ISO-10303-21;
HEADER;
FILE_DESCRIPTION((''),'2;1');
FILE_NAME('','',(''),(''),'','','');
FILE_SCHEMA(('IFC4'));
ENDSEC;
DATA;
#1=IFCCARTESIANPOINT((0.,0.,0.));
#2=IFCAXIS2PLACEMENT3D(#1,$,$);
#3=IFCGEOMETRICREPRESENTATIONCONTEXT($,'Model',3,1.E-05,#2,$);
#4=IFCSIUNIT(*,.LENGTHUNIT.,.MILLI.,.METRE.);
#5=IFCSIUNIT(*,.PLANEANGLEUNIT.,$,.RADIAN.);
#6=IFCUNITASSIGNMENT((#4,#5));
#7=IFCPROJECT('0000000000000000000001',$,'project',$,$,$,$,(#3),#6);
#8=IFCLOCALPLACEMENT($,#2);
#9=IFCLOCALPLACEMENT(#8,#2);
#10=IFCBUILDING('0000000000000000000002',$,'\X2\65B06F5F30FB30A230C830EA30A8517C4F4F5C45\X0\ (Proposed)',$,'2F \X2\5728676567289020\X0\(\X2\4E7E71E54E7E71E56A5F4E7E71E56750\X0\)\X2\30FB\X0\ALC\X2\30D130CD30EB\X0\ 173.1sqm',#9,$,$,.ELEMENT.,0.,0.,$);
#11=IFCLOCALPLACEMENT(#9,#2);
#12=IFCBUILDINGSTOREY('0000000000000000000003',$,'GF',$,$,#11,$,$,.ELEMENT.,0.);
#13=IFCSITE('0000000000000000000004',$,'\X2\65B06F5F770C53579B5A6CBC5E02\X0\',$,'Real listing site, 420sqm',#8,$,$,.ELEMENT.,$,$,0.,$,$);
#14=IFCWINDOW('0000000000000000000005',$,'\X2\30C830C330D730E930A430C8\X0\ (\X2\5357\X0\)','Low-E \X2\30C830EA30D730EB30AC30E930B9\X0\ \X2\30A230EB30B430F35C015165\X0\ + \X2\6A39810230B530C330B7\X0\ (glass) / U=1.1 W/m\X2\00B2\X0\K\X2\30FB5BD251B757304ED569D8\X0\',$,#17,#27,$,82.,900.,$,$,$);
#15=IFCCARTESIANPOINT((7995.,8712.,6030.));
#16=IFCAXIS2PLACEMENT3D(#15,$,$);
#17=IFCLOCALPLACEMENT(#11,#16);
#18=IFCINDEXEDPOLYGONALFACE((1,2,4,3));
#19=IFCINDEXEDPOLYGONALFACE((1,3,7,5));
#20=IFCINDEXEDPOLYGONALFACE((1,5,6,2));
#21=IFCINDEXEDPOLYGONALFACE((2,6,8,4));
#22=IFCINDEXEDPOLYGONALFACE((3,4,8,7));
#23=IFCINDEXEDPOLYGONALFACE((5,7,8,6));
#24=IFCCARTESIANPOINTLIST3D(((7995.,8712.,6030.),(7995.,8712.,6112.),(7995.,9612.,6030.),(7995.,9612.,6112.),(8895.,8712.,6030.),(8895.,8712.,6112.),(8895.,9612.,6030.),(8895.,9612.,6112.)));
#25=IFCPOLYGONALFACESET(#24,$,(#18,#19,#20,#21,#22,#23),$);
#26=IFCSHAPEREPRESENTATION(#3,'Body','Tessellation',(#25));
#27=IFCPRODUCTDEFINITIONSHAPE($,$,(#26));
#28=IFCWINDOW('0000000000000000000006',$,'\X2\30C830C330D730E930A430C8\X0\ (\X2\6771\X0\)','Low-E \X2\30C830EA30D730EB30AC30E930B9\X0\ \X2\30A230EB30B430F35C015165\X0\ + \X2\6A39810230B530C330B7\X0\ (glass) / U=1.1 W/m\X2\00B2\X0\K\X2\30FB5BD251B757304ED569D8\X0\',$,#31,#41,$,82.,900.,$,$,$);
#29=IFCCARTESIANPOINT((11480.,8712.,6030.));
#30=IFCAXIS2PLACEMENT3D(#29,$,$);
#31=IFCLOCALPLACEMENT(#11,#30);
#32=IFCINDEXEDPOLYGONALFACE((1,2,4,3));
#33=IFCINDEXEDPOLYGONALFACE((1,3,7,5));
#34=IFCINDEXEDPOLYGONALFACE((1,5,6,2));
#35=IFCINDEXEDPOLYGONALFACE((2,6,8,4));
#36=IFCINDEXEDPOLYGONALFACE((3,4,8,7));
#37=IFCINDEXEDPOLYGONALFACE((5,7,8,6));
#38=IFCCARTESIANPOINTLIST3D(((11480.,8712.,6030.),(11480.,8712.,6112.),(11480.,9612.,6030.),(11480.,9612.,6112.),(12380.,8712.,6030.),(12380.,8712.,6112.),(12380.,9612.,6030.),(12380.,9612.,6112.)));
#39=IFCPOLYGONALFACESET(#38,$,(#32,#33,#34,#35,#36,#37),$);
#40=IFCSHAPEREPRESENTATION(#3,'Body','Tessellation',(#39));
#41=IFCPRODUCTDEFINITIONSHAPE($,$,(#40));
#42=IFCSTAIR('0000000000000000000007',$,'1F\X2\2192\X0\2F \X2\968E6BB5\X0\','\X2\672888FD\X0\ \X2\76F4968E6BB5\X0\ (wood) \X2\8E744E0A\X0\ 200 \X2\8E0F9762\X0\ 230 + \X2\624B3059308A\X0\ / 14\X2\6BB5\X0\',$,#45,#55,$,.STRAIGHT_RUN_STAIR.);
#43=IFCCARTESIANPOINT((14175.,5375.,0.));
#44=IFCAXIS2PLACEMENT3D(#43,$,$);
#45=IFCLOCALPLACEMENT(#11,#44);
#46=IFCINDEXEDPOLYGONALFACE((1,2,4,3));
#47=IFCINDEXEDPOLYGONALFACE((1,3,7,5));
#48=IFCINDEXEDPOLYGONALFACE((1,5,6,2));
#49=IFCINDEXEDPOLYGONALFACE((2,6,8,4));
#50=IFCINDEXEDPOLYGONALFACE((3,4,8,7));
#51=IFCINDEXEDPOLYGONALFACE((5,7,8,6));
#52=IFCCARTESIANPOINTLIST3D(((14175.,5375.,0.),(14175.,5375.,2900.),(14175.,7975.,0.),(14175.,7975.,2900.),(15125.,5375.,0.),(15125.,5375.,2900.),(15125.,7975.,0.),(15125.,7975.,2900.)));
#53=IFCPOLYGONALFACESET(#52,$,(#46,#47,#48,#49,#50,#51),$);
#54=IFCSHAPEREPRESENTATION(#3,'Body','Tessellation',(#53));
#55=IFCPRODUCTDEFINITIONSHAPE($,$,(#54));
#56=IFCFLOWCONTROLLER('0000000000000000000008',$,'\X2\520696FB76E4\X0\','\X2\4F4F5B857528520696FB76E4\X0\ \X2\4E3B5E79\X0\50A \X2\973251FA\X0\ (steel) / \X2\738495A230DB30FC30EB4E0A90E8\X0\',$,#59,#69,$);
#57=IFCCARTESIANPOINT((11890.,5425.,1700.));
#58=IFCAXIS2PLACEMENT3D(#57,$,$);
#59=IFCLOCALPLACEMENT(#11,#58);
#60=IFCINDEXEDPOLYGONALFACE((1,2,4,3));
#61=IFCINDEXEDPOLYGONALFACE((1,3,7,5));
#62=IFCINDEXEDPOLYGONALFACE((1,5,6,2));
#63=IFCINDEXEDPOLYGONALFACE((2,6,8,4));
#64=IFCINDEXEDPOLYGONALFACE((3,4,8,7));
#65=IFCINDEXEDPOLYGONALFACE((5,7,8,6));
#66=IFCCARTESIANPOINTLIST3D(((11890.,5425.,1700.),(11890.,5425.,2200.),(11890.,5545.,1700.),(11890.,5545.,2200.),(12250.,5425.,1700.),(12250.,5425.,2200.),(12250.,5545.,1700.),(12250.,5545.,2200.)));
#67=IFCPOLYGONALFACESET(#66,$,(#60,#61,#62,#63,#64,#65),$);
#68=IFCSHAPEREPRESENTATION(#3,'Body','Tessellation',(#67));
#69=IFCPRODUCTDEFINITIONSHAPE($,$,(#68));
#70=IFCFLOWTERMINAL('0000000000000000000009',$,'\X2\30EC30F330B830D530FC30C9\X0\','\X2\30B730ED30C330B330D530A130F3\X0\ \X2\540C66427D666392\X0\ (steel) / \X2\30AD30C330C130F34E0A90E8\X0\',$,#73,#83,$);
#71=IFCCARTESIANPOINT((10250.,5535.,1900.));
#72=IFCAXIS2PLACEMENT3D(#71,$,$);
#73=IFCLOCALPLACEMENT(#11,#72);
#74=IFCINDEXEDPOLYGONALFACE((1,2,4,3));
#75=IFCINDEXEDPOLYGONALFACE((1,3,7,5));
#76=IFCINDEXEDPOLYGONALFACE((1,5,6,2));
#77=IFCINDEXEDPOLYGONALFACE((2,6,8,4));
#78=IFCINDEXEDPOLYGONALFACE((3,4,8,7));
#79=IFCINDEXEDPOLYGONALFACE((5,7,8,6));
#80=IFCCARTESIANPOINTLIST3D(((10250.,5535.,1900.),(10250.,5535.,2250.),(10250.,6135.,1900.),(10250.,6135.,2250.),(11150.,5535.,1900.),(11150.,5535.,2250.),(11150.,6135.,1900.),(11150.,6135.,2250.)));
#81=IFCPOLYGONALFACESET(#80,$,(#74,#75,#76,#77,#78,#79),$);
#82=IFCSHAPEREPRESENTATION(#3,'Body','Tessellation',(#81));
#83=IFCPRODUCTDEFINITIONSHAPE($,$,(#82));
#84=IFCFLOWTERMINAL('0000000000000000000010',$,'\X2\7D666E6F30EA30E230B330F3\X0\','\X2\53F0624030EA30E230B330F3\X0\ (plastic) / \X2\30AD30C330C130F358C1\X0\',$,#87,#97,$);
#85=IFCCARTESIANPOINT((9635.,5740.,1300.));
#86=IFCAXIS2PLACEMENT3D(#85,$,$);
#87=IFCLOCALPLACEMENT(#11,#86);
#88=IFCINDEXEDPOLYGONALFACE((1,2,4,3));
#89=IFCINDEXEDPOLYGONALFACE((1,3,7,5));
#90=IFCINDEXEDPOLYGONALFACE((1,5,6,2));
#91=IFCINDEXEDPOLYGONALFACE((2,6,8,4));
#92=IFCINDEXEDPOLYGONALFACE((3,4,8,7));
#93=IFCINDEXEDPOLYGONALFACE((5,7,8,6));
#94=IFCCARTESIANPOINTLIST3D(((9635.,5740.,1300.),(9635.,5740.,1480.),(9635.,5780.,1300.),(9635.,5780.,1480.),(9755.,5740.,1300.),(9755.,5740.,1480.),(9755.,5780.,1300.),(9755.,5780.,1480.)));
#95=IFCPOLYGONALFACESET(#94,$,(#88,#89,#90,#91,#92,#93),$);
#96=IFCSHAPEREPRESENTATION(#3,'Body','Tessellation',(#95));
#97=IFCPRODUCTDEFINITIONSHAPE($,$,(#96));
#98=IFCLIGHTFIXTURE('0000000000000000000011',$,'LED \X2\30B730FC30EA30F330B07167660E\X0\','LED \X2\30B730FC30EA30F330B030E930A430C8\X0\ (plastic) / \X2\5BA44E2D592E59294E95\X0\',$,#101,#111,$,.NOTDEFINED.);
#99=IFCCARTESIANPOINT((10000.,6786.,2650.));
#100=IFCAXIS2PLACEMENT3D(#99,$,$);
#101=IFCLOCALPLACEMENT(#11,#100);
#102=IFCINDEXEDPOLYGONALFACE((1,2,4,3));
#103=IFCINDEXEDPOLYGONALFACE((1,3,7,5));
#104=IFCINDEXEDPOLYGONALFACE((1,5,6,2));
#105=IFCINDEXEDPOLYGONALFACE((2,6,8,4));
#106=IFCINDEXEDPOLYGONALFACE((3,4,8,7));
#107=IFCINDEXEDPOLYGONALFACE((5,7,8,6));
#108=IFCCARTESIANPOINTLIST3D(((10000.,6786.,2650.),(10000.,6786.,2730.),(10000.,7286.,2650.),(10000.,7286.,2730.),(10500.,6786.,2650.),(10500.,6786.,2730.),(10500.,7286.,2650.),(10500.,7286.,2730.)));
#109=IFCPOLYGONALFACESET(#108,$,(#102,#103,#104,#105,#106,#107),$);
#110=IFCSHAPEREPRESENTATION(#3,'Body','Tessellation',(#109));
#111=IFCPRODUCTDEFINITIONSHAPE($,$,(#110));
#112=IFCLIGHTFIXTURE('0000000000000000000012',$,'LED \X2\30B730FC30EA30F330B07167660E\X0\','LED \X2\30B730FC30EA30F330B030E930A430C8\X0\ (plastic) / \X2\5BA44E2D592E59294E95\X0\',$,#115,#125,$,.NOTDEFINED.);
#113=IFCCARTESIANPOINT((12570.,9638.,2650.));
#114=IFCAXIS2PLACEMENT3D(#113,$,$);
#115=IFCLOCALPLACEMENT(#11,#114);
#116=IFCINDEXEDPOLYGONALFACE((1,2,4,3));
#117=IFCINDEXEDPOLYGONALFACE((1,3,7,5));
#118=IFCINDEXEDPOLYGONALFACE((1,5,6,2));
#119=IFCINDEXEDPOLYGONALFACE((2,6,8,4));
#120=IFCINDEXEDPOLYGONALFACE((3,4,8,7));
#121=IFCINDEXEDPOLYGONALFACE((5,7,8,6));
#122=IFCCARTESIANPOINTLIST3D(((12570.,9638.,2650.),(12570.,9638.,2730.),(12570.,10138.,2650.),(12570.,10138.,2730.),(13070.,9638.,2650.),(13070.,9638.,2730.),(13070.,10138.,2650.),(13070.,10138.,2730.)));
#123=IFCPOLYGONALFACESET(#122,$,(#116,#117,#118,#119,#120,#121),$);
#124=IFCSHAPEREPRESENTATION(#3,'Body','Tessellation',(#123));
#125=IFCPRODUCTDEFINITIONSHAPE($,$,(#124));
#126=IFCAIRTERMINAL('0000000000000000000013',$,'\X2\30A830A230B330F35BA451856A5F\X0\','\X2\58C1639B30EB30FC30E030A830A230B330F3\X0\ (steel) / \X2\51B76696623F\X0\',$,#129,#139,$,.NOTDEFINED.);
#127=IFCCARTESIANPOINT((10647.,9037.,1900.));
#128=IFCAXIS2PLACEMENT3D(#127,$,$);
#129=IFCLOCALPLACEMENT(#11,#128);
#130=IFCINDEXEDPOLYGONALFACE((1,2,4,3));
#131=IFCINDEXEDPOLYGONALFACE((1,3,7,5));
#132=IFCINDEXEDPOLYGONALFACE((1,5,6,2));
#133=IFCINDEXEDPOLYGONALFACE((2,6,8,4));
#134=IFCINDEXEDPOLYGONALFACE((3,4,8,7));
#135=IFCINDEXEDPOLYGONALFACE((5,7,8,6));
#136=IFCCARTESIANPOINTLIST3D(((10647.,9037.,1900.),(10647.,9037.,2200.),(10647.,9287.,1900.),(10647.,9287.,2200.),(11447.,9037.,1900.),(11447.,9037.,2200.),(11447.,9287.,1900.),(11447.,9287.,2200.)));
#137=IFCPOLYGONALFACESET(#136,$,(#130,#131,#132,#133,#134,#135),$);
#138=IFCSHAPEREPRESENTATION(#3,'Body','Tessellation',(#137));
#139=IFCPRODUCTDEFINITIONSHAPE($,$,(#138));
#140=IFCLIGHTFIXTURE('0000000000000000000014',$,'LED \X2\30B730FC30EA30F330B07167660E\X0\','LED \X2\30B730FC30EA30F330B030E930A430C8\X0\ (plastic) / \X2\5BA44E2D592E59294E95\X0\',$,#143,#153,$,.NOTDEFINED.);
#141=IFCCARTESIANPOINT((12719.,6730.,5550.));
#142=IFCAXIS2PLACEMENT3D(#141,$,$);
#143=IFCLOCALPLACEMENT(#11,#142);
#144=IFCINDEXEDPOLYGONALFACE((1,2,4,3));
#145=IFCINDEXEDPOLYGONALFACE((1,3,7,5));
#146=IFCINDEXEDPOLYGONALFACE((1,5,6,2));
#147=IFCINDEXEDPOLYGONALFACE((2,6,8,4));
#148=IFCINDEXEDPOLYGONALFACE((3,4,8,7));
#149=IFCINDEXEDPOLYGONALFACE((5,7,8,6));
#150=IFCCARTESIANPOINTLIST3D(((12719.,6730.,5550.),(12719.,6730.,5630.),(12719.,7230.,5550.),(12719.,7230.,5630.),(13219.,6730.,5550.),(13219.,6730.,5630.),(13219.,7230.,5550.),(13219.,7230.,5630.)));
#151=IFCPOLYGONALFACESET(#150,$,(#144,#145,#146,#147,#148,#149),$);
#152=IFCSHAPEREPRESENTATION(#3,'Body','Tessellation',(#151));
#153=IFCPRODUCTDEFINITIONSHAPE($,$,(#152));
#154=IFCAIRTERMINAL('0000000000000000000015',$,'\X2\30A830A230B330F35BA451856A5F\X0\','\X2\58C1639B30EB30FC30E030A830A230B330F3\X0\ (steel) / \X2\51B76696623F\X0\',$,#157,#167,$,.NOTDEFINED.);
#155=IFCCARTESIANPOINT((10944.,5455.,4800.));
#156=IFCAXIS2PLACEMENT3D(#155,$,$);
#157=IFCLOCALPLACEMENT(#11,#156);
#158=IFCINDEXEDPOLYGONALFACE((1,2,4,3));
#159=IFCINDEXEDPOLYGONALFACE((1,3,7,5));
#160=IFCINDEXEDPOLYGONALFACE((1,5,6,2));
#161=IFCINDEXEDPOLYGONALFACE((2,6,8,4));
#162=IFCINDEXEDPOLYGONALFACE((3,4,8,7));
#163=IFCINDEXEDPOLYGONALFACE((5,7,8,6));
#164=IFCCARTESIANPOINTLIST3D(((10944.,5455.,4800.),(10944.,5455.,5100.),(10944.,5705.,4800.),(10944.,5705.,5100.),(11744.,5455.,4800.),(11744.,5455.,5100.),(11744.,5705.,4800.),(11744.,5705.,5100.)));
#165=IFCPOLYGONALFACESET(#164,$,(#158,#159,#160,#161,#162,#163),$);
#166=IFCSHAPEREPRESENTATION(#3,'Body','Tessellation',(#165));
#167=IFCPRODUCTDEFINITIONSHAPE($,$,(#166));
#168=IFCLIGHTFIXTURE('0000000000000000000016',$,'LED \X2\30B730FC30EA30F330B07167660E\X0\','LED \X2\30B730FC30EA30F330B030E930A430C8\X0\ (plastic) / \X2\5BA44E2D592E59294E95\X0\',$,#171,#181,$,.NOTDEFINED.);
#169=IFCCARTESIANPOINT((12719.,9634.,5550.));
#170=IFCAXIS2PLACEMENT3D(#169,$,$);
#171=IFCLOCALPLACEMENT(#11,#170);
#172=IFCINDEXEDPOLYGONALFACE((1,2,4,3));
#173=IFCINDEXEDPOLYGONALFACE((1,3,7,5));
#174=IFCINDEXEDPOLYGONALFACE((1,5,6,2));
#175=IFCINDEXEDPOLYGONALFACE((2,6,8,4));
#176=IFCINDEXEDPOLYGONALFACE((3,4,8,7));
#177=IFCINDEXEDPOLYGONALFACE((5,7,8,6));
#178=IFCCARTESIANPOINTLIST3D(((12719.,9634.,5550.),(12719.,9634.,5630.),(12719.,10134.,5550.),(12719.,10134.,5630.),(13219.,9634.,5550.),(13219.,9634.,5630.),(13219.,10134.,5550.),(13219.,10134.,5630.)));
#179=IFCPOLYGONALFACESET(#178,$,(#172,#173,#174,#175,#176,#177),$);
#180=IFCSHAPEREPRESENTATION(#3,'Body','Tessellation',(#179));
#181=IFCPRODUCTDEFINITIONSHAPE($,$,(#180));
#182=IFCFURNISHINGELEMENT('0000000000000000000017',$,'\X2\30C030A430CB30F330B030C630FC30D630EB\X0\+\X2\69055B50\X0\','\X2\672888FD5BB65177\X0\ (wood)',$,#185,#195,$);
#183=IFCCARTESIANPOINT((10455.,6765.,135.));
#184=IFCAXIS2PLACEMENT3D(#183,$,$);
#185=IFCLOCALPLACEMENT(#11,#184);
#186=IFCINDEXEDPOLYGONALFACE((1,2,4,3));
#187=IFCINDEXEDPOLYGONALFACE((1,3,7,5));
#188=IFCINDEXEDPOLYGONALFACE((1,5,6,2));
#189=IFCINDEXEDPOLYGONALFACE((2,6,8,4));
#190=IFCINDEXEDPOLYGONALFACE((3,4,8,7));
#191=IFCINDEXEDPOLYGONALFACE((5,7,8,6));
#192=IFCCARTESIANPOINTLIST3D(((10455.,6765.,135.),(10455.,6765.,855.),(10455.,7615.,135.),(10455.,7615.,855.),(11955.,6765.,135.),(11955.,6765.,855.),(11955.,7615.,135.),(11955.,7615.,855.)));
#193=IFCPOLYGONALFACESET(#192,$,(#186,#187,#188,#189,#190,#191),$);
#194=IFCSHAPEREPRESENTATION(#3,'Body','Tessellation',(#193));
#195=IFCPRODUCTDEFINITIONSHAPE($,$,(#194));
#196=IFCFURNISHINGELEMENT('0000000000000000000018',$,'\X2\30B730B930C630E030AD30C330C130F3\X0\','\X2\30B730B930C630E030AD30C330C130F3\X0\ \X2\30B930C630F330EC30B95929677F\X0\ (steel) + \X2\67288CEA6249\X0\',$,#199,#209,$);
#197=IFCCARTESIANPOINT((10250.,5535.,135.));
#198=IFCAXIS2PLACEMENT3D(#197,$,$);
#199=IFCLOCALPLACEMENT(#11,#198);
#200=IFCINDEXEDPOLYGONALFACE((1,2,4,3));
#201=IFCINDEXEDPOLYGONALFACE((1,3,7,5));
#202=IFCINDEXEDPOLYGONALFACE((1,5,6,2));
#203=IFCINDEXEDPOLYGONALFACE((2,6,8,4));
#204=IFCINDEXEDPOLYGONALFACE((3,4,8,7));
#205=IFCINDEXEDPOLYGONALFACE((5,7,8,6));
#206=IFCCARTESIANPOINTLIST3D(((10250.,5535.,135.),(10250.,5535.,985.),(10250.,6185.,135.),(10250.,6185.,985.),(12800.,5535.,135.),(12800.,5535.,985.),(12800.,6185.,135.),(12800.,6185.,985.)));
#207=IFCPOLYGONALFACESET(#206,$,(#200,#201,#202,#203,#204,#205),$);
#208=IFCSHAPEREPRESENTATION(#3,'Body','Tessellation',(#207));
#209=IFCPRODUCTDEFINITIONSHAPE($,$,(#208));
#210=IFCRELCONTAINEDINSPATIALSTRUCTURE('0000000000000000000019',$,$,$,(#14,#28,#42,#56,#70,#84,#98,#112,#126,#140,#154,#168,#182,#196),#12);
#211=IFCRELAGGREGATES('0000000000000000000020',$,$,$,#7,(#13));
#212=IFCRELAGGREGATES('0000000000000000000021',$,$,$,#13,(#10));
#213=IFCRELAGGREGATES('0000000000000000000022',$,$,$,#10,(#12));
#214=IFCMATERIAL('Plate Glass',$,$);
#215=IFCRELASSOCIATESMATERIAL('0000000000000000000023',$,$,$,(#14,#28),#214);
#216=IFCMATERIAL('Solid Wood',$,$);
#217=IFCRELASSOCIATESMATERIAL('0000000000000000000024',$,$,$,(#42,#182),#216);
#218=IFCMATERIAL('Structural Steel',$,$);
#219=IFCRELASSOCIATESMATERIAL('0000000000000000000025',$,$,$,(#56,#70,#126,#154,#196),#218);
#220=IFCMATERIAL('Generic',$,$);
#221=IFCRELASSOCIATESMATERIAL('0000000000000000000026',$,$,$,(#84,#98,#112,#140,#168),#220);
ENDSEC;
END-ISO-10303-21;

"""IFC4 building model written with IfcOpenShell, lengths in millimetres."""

from ifc_helpers import new_model, si_unit, frame, frame_2d, origin, place, context, project, spatial, rectangle, extrude, material, element, save


model = new_model("IFC4")

# Units and contexts
model_context = context("Model", 3, precision=1e-05, world=origin())
ifc_project = project(units=[si_unit("LENGTHUNIT", "METRE", prefix="MILLI"), si_unit("PLANEANGLEUNIT", "RADIAN")], contexts=[model_context])

# Site, building, storey
site_placement = place(None, origin())
site = spatial("IfcSite", under=ifc_project, at=site_placement, Name="新潟県南魚沼市", ObjectType="Real listing site, 420sqm", CompositionType="ELEMENT", RefElevation=0.0)
building_placement = place(site_placement, origin())
building = spatial("IfcBuilding", under=site, at=building_placement, Name="新潟・アトリエ兼住居 (Proposed)", ObjectType="2F 在来木造(乾燥乾燥機乾燥材)・ALCパネル 173.1sqm", CompositionType="ELEMENT", ElevationOfRefHeight=0.0, ElevationOfTerrain=0.0)
storey_placement = place(building_placement, origin())
storey = spatial("IfcBuildingStorey", under=building, at=storey_placement, Name="GF", CompositionType="ELEMENT", Elevation=0.0)

# Shared definitions
ifc_material_1 = material(Name="Solid Wood")

# Windows
ifc_material_2 = material(Name="Plate Glass")
window_1_placement = place(storey_placement, frame((7995.0, 8712.0, 6030.0)))
element("IfcWindow", 1, at=window_1_placement, inside=storey, material=ifc_material_2, Name="トップライト (南)", Description="Low-E トリプルガラス アルゴン封入 + 樹脂サッシ (glass) / U=1.1 W/m²K・寒冷地仕様", OverallHeight=82.0, OverallWidth=900.0, context=model_context, shape_type="SweptSolid", body=[
    extrude(rectangle(XDim=900.0, YDim=900.0, at=frame_2d((450.0, 450.0))), frame((7995.0, 8712.0, 6030.0)), (0.0, 0.0, 1.0), 82.0),
])
window_2_placement = place(storey_placement, frame((11480.0, 8712.0, 6030.0)))
element("IfcWindow", 2, at=window_2_placement, inside=storey, material=ifc_material_2, Name="トップライト (東)", Description="Low-E トリプルガラス アルゴン封入 + 樹脂サッシ (glass) / U=1.1 W/m²K・寒冷地仕様", OverallHeight=82.0, OverallWidth=900.0, context=model_context, shape_type="SweptSolid", body=[
    extrude(rectangle(XDim=900.0, YDim=900.0, at=frame_2d((450.0, 450.0))), frame((11480.0, 8712.0, 6030.0)), (0.0, 0.0, 1.0), 82.0),
])

# Stair
stair_placement = place(storey_placement, frame((14175.0, 5375.0, 0.0)))
element("IfcStair", 3, at=stair_placement, inside=storey, material=ifc_material_1, Name="1F→2F 階段", Description="木製 直階段 (wood) 蹴上 200 踏面 230 + 手すり / 14段", PredefinedType="STRAIGHT_RUN_STAIR", context=model_context, shape_type="SweptSolid", body=[
    extrude(rectangle(XDim=950.0, YDim=2600.0, at=frame_2d((475.0, 1300.0))), frame((14175.0, 5375.0, 0.0)), (0.0, 0.0, 1.0), 2900.0),
])

# Flow controller
ifc_material_3 = material(Name="Structural Steel")
flow_controller_placement = place(storey_placement, frame((11890.0, 5425.0, 1700.0)))
element("IfcFlowController", 4, at=flow_controller_placement, inside=storey, material=ifc_material_3, Name="分電盤", Description="住宅用分電盤 主幹50A 露出 (steel) / 玄関ホール上部", context=model_context, shape_type="SweptSolid", body=[
    extrude(rectangle(XDim=360.0, YDim=120.0, at=frame_2d((180.0, 60.0))), frame((11890.0, 5425.0, 1700.0)), (0.0, 0.0, 1.0), 500.0),
])

# Flow terminals
flow_terminal_1_placement = place(storey_placement, frame((10250.0, 5535.0, 1900.0)))
element("IfcFlowTerminal", 5, at=flow_terminal_1_placement, inside=storey, material=ifc_material_3, Name="レンジフード", Description="シロッコファン 同時給排 (steel) / キッチン上部", context=model_context, shape_type="SweptSolid", body=[
    extrude(rectangle(XDim=900.0, YDim=600.0, at=frame_2d((450.0, 300.0))), frame((10250.0, 5535.0, 1900.0)), (0.0, 0.0, 1.0), 350.0),
])
ifc_material_4 = material(Name="Generic")
flow_terminal_2_placement = place(storey_placement, frame((9635.0, 5740.0, 1300.0)))
element("IfcFlowTerminal", 6, at=flow_terminal_2_placement, inside=storey, material=ifc_material_4, Name="給湯リモコン", Description="台所リモコン (plastic) / キッチン壁", context=model_context, shape_type="SweptSolid", body=[
    extrude(rectangle(XDim=120.0, YDim=40.0, at=frame_2d((60.0, 20.0))), frame((9635.0, 5740.0, 1300.0)), (0.0, 0.0, 1.0), 180.0),
])

# Light fixtures
light_fixture_1_placement = place(storey_placement, frame((10000.0, 6786.0, 2650.0)))
element("IfcLightFixture", 7, at=light_fixture_1_placement, inside=storey, material=ifc_material_4, Name="LED シーリング照明", Description="LED シーリングライト (plastic) / 室中央天井", PredefinedType="NOTDEFINED", context=model_context, shape_type="SweptSolid", body=[
    extrude(rectangle(XDim=500.0, YDim=500.0, at=frame_2d((250.0, 250.0))), frame((10000.0, 6786.0, 2650.0)), (0.0, 0.0, 1.0), 80.0),
])
light_fixture_2_placement = place(storey_placement, frame((12570.0, 9638.0, 2650.0)))
element("IfcLightFixture", 8, at=light_fixture_2_placement, inside=storey, material=ifc_material_4, Name="LED シーリング照明", Description="LED シーリングライト (plastic) / 室中央天井", PredefinedType="NOTDEFINED", context=model_context, shape_type="SweptSolid", body=[
    extrude(rectangle(XDim=500.0, YDim=500.0, at=frame_2d((250.0, 250.0))), frame((12570.0, 9638.0, 2650.0)), (0.0, 0.0, 1.0), 80.0),
])

# Air terminal
air_terminal_1_placement = place(storey_placement, frame((10647.0, 9037.0, 1900.0)))
element("IfcAirTerminal", 9, at=air_terminal_1_placement, inside=storey, material=ifc_material_3, Name="エアコン室内機", Description="壁掛ルームエアコン (steel) / 冷暖房", PredefinedType="NOTDEFINED", context=model_context, shape_type="SweptSolid", body=[
    extrude(rectangle(XDim=800.0, YDim=250.0, at=frame_2d((400.0, 125.0))), frame((10647.0, 9037.0, 1900.0)), (0.0, 0.0, 1.0), 300.0),
])

# Light fixture
light_fixture_3_placement = place(storey_placement, frame((12719.0, 6730.0, 5550.0)))
element("IfcLightFixture", 10, at=light_fixture_3_placement, inside=storey, material=ifc_material_4, Name="LED シーリング照明", Description="LED シーリングライト (plastic) / 室中央天井", PredefinedType="NOTDEFINED", context=model_context, shape_type="SweptSolid", body=[
    extrude(rectangle(XDim=500.0, YDim=500.0, at=frame_2d((250.0, 250.0))), frame((12719.0, 6730.0, 5550.0)), (0.0, 0.0, 1.0), 80.0),
])

# Air terminal
air_terminal_2_placement = place(storey_placement, frame((10944.0, 5455.0, 4800.0)))
element("IfcAirTerminal", 11, at=air_terminal_2_placement, inside=storey, material=ifc_material_3, Name="エアコン室内機", Description="壁掛ルームエアコン (steel) / 冷暖房", PredefinedType="NOTDEFINED", context=model_context, shape_type="SweptSolid", body=[
    extrude(rectangle(XDim=800.0, YDim=250.0, at=frame_2d((400.0, 125.0))), frame((10944.0, 5455.0, 4800.0)), (0.0, 0.0, 1.0), 300.0),
])

# Light fixture
light_fixture_4_placement = place(storey_placement, frame((12719.0, 9634.0, 5550.0)))
element("IfcLightFixture", 12, at=light_fixture_4_placement, inside=storey, material=ifc_material_4, Name="LED シーリング照明", Description="LED シーリングライト (plastic) / 室中央天井", PredefinedType="NOTDEFINED", context=model_context, shape_type="SweptSolid", body=[
    extrude(rectangle(XDim=500.0, YDim=500.0, at=frame_2d((250.0, 250.0))), frame((12719.0, 9634.0, 5550.0)), (0.0, 0.0, 1.0), 80.0),
])

# Furnishing elements
furnishing_1_placement = place(storey_placement, frame((10455.0, 6765.0, 135.0)))
element("IfcFurnishingElement", 13, at=furnishing_1_placement, inside=storey, material=ifc_material_1, Name="ダイニングテーブル+椅子", Description="木製家具 (wood)", context=model_context, shape_type="SweptSolid", body=[
    extrude(rectangle(XDim=1500.0, YDim=850.0, at=frame_2d((750.0, 425.0))), frame((10455.0, 6765.0, 135.0)), (0.0, 0.0, 1.0), 720.0),
])
furnishing_2_placement = place(storey_placement, frame((10250.0, 5535.0, 135.0)))
element("IfcFurnishingElement", 14, at=furnishing_2_placement, inside=storey, material=ifc_material_3, Name="システムキッチン", Description="システムキッチン ステンレス天板 (steel) + 木質扉", context=model_context, shape_type="SweptSolid", body=[
    extrude(rectangle(XDim=2550.0, YDim=650.0, at=frame_2d((1275.0, 325.0))), frame((10250.0, 5535.0, 135.0)), (0.0, 0.0, 1.0), 850.0),
])

save(model, "model.ifc")
